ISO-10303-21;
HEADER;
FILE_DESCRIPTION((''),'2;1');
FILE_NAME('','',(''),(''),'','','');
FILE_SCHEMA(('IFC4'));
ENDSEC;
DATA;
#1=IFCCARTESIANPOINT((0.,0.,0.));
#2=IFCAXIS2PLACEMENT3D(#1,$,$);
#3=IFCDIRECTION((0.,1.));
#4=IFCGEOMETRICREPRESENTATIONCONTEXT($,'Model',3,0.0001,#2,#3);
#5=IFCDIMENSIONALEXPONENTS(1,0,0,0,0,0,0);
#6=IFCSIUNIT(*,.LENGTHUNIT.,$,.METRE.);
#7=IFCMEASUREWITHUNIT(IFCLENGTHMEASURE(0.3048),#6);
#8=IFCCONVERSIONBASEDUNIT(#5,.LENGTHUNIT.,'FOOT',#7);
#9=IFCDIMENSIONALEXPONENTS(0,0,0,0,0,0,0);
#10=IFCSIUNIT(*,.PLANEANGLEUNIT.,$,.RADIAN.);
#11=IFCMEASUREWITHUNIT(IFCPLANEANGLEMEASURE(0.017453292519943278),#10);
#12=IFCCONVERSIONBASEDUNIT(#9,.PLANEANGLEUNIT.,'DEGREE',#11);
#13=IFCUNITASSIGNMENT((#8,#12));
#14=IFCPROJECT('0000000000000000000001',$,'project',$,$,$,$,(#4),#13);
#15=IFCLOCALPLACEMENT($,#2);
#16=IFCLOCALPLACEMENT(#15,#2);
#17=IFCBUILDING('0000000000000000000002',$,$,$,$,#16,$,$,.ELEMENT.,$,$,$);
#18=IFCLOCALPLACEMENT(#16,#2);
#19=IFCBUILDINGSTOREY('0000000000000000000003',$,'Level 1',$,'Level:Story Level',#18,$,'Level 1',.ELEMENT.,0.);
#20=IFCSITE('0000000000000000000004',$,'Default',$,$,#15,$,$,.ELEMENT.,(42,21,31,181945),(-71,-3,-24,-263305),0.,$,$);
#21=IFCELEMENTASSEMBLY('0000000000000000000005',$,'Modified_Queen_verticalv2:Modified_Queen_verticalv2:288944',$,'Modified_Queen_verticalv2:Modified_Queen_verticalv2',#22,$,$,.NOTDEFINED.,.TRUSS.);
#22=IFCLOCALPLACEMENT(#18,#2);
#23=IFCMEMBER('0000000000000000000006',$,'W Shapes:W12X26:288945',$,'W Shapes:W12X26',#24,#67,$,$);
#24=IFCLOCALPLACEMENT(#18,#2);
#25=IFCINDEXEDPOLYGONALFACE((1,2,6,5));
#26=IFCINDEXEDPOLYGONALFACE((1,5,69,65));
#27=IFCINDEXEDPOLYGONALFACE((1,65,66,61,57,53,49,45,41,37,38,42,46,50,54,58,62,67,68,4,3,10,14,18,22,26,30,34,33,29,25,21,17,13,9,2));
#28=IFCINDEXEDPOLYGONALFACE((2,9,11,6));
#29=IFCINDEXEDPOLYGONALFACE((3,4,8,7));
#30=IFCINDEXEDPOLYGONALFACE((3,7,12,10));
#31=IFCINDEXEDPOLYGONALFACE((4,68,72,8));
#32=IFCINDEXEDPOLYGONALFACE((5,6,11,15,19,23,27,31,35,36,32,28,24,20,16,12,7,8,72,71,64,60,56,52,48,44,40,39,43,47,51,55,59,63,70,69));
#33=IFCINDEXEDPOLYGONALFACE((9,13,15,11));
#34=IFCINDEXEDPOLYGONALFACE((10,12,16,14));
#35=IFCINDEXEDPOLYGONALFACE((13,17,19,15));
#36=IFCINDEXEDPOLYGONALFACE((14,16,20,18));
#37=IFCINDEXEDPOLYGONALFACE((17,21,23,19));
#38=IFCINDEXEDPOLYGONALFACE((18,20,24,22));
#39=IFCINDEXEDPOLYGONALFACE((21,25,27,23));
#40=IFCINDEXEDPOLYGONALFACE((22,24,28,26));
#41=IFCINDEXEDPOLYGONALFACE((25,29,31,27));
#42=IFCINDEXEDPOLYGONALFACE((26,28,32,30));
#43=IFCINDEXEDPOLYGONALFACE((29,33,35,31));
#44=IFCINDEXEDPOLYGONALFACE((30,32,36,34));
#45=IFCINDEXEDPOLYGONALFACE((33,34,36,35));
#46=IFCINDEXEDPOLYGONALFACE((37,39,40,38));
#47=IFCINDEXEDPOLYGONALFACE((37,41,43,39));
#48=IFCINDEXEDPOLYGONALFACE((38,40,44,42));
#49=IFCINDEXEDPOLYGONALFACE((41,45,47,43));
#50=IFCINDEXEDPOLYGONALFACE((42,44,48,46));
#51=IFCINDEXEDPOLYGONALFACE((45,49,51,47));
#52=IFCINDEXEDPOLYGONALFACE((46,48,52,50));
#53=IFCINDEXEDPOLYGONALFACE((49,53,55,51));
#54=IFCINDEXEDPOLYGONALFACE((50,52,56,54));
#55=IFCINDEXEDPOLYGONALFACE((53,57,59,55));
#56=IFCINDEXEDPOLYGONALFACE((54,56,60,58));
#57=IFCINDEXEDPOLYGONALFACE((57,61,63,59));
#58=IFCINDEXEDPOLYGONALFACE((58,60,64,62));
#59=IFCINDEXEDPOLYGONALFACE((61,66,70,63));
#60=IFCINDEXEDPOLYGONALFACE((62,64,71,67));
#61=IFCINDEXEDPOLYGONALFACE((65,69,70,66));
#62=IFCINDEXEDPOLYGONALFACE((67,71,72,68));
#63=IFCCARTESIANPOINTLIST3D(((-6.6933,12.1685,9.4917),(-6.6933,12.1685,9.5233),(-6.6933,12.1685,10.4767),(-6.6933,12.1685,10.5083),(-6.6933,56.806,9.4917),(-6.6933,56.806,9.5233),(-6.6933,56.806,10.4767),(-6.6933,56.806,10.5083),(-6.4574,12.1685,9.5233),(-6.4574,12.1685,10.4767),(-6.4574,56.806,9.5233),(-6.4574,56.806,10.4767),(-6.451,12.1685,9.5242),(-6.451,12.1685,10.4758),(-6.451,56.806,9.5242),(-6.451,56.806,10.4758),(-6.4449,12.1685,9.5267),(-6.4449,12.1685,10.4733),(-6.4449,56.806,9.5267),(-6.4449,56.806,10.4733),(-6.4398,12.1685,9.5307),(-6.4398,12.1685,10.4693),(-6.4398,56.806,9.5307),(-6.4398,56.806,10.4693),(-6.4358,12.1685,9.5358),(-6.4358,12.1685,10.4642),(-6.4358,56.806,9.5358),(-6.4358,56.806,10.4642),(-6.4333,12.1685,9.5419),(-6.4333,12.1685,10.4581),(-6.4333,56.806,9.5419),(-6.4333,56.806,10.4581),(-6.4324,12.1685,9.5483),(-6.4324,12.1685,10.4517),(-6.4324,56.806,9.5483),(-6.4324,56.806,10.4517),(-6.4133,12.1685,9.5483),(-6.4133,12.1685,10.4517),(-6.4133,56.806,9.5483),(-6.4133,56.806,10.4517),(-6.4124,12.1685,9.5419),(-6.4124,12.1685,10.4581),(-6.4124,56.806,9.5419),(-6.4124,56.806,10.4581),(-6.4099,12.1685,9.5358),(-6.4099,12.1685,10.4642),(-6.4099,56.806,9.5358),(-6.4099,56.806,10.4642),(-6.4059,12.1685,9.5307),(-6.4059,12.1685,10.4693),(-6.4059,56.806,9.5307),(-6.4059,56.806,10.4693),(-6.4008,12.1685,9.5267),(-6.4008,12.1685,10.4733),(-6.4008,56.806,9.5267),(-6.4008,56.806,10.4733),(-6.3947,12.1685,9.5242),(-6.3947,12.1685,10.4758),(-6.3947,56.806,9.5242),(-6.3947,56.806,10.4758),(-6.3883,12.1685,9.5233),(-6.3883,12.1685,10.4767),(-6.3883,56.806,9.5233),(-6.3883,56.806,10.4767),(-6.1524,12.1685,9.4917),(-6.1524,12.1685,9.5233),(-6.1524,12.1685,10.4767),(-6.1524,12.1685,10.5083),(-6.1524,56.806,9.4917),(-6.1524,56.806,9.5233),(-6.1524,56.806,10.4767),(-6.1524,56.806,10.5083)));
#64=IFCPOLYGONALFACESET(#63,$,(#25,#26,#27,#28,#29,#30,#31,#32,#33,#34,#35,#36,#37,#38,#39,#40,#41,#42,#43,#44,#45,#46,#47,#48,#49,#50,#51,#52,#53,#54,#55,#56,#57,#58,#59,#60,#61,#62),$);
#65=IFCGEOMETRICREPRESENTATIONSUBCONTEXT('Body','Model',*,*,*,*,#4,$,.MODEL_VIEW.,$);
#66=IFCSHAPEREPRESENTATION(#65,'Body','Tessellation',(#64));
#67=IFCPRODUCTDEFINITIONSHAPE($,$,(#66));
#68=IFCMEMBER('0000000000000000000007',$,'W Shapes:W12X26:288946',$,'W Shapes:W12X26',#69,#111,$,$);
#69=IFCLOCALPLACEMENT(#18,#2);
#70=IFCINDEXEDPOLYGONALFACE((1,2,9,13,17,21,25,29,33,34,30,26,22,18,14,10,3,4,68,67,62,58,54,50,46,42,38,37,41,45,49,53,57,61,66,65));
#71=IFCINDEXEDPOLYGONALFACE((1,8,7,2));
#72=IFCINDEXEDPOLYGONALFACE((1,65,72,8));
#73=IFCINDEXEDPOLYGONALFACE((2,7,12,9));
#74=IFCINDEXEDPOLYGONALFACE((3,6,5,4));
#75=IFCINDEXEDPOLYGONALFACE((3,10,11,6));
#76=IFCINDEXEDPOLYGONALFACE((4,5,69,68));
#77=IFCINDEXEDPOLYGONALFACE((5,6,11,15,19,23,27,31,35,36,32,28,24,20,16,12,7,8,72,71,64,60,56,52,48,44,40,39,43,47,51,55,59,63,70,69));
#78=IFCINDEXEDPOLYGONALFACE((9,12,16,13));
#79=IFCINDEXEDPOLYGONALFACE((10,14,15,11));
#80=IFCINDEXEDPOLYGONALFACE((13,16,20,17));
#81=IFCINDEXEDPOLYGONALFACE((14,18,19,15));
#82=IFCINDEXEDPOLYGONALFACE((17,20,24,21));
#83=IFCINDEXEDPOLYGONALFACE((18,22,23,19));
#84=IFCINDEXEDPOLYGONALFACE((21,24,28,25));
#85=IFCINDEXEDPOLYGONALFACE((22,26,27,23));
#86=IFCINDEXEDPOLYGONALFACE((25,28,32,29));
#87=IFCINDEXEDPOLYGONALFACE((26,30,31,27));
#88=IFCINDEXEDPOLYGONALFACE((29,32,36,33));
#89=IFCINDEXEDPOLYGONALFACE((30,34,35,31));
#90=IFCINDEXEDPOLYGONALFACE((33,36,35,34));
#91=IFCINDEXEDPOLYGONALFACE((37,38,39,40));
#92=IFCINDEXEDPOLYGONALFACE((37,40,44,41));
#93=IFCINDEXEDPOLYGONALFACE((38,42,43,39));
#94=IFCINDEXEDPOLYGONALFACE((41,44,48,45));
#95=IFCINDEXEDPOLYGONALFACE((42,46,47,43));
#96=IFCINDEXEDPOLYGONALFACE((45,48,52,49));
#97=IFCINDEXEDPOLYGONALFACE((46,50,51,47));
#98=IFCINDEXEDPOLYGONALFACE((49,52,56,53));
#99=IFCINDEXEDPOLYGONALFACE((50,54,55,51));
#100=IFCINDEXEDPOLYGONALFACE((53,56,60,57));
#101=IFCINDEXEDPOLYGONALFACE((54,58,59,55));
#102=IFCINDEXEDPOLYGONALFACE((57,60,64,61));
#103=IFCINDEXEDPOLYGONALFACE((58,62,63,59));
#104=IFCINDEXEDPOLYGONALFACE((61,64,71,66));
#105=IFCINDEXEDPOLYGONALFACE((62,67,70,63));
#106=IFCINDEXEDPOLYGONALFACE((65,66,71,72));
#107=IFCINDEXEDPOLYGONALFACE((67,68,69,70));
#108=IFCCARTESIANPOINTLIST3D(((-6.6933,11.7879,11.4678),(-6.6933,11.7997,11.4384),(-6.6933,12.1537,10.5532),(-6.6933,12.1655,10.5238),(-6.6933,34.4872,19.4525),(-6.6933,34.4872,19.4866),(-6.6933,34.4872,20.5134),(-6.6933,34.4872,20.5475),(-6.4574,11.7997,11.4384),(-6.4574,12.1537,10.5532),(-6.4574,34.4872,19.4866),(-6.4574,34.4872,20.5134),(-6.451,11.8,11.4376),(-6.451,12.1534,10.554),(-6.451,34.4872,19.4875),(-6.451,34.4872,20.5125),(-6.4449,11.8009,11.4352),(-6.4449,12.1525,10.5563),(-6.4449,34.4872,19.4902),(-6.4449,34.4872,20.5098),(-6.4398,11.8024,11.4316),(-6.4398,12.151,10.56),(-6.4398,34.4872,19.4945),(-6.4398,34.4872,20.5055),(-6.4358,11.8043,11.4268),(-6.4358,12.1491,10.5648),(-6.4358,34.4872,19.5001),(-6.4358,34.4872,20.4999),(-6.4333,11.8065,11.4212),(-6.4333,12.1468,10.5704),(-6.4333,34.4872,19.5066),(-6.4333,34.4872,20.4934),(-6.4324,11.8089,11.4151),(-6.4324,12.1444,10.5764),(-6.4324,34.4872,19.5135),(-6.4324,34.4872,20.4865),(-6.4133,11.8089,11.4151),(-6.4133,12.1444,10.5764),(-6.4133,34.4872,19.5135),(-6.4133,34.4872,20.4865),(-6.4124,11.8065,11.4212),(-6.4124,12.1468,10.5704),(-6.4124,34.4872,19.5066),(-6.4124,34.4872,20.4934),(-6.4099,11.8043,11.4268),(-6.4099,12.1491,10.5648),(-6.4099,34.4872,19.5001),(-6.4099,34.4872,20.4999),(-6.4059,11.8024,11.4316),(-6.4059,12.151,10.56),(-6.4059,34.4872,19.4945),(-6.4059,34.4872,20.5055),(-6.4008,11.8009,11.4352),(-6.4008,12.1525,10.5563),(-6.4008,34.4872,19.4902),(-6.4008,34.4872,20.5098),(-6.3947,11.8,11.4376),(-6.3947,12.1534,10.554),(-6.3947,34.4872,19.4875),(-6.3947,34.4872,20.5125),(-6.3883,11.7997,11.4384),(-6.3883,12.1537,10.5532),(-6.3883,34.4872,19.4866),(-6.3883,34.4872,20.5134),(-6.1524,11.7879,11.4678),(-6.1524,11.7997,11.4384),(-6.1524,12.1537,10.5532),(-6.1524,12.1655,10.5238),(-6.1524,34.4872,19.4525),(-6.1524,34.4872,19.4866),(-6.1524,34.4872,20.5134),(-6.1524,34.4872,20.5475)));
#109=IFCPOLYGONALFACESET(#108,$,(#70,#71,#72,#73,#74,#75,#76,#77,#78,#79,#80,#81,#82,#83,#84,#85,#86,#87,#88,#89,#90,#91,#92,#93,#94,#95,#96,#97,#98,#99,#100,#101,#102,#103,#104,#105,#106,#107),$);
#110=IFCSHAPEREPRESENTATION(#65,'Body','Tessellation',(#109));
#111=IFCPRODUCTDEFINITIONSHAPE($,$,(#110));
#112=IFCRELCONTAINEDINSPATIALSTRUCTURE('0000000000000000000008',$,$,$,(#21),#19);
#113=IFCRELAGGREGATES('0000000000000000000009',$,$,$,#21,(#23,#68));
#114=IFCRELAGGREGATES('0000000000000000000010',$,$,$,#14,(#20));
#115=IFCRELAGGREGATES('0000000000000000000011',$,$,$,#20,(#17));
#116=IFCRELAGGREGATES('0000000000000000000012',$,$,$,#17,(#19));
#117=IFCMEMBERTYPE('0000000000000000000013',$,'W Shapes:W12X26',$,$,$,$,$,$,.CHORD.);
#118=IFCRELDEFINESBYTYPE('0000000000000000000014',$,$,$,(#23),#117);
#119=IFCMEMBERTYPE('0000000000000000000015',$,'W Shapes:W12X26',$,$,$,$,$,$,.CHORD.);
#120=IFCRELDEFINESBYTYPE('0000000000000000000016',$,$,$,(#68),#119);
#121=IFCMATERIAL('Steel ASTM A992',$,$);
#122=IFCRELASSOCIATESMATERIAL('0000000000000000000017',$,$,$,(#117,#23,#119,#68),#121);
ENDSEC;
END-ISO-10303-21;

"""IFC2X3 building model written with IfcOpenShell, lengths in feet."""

from ifc_helpers import new_model, entity, si_unit, converted_unit, direction, frame, frame_2d, origin, place, context, subcontext, project, spatial, polyline, circle_curve, parameter, trimmed, segment, composite_curve, outline, extrude, clip, halfspace, source, transform, mapped, material, type_object, type_shapes, element, aggregate, save


model = new_model("IFC2X3")

# Units and contexts
model_context = context("Model", 3, precision=0.0001, world=origin(), true_north=direction((0.0, 1.0)))
body_context = subcontext(model_context, "Body", "Model", "MODEL_VIEW")
ifc_project = project(units=[converted_unit("LENGTHUNIT", "FOOT", entity("IfcLengthMeasure", 0.3048), si_unit("LENGTHUNIT", "METRE"), dimensions=[1, 0, 0, 0, 0, 0, 0]), converted_unit("PLANEANGLEUNIT", "DEGREE", entity("IfcPlaneAngleMeasure", 0.017453292519943278), si_unit("PLANEANGLEUNIT", "RADIAN"), dimensions=[0, 0, 0, 0, 0, 0, 0])], contexts=[model_context])

# Site, building, storey
site_placement = place(None, origin())
site = spatial("IfcSite", under=ifc_project, at=site_placement, Name="Default", CompositionType="ELEMENT", RefLatitude=(42, 21, 31, 181945), RefLongitude=(-71, -3, -24, -263305), RefElevation=0.0)
building_placement = place(site_placement, origin())
building = spatial("IfcBuilding", under=site, at=building_placement, CompositionType="ELEMENT")
storey_placement = place(building_placement, origin())
storey = spatial("IfcBuildingStorey", under=building, at=storey_placement, Name="Level 1", ObjectType="Level:Story Level", LongName="Level 1", CompositionType="ELEMENT", Elevation=0.0)

# Element assembly, members
assembly_placement = place(storey_placement, origin())
assembly = element("IfcElementAssembly", 1, at=assembly_placement, inside=storey, Name="Modified_Queen_verticalv2:Modified_Queen_verticalv2:288944", ObjectType="Modified_Queen_verticalv2:Modified_Queen_verticalv2", AssemblyPlace="NOTDEFINED", PredefinedType="TRUSS")
ifc_material = material(Name="Steel ASTM A992")
member_type_1 = type_object("IfcMemberType", Name="W Shapes:W12X26", PredefinedType="CHORD", material=ifc_material)
shared_shape_1 = source(origin(), body_context, "Body", "SweptSolid", [
    extrude(outline(composite_curve([segment(polyline([(-0.2704, -0.4767), (-0.2704, -0.5083)]), True, "CONTINUOUS"), segment(polyline([(-0.2704, -0.5083), (0.2704, -0.5083)]), True, "CONTINUOUS"), segment(polyline([(0.2704, -0.5083), (0.2704, -0.4767)]), True, "CONTINUOUS"), segment(polyline([(0.2704, -0.4767), (0.0346, -0.4767)]), True, "CONTINUOUS"), segment(trimmed(circle_curve(frame_2d((0.0346, -0.4517), x_axis=(1.0, 0.0)), 0.025), [parameter(180.0)], [parameter(270.0)], True, "PARAMETER"), False, "CONTINUOUS"), segment(polyline([(0.0096, -0.4517), (0.0096, 0.4517)]), True, "CONTINUOUS"), segment(trimmed(circle_curve(frame_2d((0.0346, 0.4517), x_axis=(1.0, 0.0)), 0.025), [parameter(90.0)], [parameter(180.0)], True, "PARAMETER"), False, "CONTINUOUS"), segment(polyline([(0.0346, 0.4767), (0.2704, 0.4767)]), True, "CONTINUOUS"), segment(polyline([(0.2704, 0.4767), (0.2704, 0.5083)]), True, "CONTINUOUS"), segment(polyline([(0.2704, 0.5083), (-0.2704, 0.5083)]), True, "CONTINUOUS"), segment(polyline([(-0.2704, 0.5083), (-0.2704, 0.4767)]), True, "CONTINUOUS"), segment(polyline([(-0.2704, 0.4767), (-0.0346, 0.4767)]), True, "CONTINUOUS"), segment(trimmed(circle_curve(frame_2d((-0.0346, 0.4517), x_axis=(1.0, 0.0)), 0.025), [parameter(360.0)], [parameter(90.0)], True, "PARAMETER"), False, "CONTINUOUS"), segment(polyline([(-0.0096, 0.4517), (-0.0096, -0.4517)]), True, "CONTINUOUS"), segment(trimmed(circle_curve(frame_2d((-0.0346, -0.4517), x_axis=(1.0, 0.0)), 0.025), [parameter(270.0)], [parameter(360.0)], True, "PARAMETER"), False, "CONTINUOUS"), segment(polyline([(-0.0346, -0.4767), (-0.2704, -0.4767)]), True, "CONTINUOUS")], self_intersect=False)), frame((-22.3188, 0.0, 0.0), z_axis=(-1.0, 0.0, 0.0), x_axis=(0.0, -1.0, 0.0)), (0.0, 0.0, -1.0), 44.6375),
])
type_shapes(member_type_1, [shared_shape_1])
member_1_placement = place(assembly_placement, frame((-6.4228, 34.4872, 10.0), z_axis=(0.0, 0.0, 1.0), x_axis=(0.0, 1.0, 0.0)))
member_1 = element("IfcMember", 2, at=member_1_placement, type_object=member_type_1, material=ifc_material, Name="W Shapes:W12X26:288945", ObjectType="W Shapes:W12X26", context=body_context, shape_type="MappedRepresentation", body=[
    mapped(shared_shape_1, transform((0.0, 0.0, 0.0), scale=1.0)),
])
member_type_2 = type_object("IfcMemberType", Name="W Shapes:W12X26", PredefinedType="CHORD", material=ifc_material)
shared_shape_2 = source(origin(), body_context, "Body", "SweptSolid", [
    clip(extrude(outline(composite_curve([segment(polyline([(0.4767, -0.2704), (0.5083, -0.2704)]), True, "CONTINUOUS"), segment(polyline([(0.5083, -0.2704), (0.5083, 0.2704)]), True, "CONTINUOUS"), segment(polyline([(0.5083, 0.2704), (0.4767, 0.2704)]), True, "CONTINUOUS"), segment(polyline([(0.4767, 0.2704), (0.4767, 0.0346)]), True, "CONTINUOUS"), segment(trimmed(circle_curve(frame_2d((0.4517, 0.0346), x_axis=(1.0, 0.0)), 0.025), [parameter(270.0)], [parameter(0.0)], True, "PARAMETER"), False, "CONTINUOUS"), segment(polyline([(0.4517, 0.0096), (-0.4517, 0.0096)]), True, "CONTINUOUS"), segment(trimmed(circle_curve(frame_2d((-0.4517, 0.0346), x_axis=(0.0, -1.0)), 0.025), [parameter(270.0)], [parameter(0.0)], True, "PARAMETER"), False, "CONTINUOUS"), segment(polyline([(-0.4767, 0.0346), (-0.4767, 0.2704)]), True, "CONTINUOUS"), segment(polyline([(-0.4767, 0.2704), (-0.5083, 0.2704)]), True, "CONTINUOUS"), segment(polyline([(-0.5083, 0.2704), (-0.5083, -0.2704)]), True, "CONTINUOUS"), segment(polyline([(-0.5083, -0.2704), (-0.4767, -0.2704)]), True, "CONTINUOUS"), segment(polyline([(-0.4767, -0.2704), (-0.4767, -0.0346)]), True, "CONTINUOUS"), segment(trimmed(circle_curve(frame_2d((-0.4517, -0.0346), x_axis=(-1.0, 0.0)), 0.025), [parameter(270.0)], [parameter(0.0)], True, "PARAMETER"), False, "CONTINUOUS"), segment(polyline([(-0.4517, -0.0096), (0.4517, -0.0096)]), True, "CONTINUOUS"), segment(trimmed(circle_curve(frame_2d((0.4517, -0.0346), x_axis=(0.0, 1.0)), 0.025), [parameter(270.0)], [parameter(0.0)], True, "PARAMETER"), False, "CONTINUOUS"), segment(polyline([(0.4767, -0.0346), (0.4767, -0.2704)]), True, "CONTINUOUS")], self_intersect=False)), frame((-6.4228, 11.9767, 10.9958), z_axis=(0.0, 0.928477, 0.371391), x_axis=(0.0, -0.371391, 0.928477)), (0.0, 0.0, 1.0), 24.4479), halfspace(frame((-6.4228, 34.4872, 20.5475), z_axis=(0.0, 1.0, 0.0), x_axis=(0.0, 0.0, -1.0)), False)),
])
type_shapes(member_type_2, [shared_shape_2])
member_2_placement = place(assembly_placement, origin())
member_2 = element("IfcMember", 3, at=member_2_placement, type_object=member_type_2, material=ifc_material, Name="W Shapes:W12X26:288946", ObjectType="W Shapes:W12X26", context=body_context, shape_type="MappedRepresentation", body=[
    mapped(shared_shape_2, transform((0.0, 0.0, 0.0), scale=1.0)),
])
aggregate(assembly, [member_1, member_2])

save(model, "model.ifc")
